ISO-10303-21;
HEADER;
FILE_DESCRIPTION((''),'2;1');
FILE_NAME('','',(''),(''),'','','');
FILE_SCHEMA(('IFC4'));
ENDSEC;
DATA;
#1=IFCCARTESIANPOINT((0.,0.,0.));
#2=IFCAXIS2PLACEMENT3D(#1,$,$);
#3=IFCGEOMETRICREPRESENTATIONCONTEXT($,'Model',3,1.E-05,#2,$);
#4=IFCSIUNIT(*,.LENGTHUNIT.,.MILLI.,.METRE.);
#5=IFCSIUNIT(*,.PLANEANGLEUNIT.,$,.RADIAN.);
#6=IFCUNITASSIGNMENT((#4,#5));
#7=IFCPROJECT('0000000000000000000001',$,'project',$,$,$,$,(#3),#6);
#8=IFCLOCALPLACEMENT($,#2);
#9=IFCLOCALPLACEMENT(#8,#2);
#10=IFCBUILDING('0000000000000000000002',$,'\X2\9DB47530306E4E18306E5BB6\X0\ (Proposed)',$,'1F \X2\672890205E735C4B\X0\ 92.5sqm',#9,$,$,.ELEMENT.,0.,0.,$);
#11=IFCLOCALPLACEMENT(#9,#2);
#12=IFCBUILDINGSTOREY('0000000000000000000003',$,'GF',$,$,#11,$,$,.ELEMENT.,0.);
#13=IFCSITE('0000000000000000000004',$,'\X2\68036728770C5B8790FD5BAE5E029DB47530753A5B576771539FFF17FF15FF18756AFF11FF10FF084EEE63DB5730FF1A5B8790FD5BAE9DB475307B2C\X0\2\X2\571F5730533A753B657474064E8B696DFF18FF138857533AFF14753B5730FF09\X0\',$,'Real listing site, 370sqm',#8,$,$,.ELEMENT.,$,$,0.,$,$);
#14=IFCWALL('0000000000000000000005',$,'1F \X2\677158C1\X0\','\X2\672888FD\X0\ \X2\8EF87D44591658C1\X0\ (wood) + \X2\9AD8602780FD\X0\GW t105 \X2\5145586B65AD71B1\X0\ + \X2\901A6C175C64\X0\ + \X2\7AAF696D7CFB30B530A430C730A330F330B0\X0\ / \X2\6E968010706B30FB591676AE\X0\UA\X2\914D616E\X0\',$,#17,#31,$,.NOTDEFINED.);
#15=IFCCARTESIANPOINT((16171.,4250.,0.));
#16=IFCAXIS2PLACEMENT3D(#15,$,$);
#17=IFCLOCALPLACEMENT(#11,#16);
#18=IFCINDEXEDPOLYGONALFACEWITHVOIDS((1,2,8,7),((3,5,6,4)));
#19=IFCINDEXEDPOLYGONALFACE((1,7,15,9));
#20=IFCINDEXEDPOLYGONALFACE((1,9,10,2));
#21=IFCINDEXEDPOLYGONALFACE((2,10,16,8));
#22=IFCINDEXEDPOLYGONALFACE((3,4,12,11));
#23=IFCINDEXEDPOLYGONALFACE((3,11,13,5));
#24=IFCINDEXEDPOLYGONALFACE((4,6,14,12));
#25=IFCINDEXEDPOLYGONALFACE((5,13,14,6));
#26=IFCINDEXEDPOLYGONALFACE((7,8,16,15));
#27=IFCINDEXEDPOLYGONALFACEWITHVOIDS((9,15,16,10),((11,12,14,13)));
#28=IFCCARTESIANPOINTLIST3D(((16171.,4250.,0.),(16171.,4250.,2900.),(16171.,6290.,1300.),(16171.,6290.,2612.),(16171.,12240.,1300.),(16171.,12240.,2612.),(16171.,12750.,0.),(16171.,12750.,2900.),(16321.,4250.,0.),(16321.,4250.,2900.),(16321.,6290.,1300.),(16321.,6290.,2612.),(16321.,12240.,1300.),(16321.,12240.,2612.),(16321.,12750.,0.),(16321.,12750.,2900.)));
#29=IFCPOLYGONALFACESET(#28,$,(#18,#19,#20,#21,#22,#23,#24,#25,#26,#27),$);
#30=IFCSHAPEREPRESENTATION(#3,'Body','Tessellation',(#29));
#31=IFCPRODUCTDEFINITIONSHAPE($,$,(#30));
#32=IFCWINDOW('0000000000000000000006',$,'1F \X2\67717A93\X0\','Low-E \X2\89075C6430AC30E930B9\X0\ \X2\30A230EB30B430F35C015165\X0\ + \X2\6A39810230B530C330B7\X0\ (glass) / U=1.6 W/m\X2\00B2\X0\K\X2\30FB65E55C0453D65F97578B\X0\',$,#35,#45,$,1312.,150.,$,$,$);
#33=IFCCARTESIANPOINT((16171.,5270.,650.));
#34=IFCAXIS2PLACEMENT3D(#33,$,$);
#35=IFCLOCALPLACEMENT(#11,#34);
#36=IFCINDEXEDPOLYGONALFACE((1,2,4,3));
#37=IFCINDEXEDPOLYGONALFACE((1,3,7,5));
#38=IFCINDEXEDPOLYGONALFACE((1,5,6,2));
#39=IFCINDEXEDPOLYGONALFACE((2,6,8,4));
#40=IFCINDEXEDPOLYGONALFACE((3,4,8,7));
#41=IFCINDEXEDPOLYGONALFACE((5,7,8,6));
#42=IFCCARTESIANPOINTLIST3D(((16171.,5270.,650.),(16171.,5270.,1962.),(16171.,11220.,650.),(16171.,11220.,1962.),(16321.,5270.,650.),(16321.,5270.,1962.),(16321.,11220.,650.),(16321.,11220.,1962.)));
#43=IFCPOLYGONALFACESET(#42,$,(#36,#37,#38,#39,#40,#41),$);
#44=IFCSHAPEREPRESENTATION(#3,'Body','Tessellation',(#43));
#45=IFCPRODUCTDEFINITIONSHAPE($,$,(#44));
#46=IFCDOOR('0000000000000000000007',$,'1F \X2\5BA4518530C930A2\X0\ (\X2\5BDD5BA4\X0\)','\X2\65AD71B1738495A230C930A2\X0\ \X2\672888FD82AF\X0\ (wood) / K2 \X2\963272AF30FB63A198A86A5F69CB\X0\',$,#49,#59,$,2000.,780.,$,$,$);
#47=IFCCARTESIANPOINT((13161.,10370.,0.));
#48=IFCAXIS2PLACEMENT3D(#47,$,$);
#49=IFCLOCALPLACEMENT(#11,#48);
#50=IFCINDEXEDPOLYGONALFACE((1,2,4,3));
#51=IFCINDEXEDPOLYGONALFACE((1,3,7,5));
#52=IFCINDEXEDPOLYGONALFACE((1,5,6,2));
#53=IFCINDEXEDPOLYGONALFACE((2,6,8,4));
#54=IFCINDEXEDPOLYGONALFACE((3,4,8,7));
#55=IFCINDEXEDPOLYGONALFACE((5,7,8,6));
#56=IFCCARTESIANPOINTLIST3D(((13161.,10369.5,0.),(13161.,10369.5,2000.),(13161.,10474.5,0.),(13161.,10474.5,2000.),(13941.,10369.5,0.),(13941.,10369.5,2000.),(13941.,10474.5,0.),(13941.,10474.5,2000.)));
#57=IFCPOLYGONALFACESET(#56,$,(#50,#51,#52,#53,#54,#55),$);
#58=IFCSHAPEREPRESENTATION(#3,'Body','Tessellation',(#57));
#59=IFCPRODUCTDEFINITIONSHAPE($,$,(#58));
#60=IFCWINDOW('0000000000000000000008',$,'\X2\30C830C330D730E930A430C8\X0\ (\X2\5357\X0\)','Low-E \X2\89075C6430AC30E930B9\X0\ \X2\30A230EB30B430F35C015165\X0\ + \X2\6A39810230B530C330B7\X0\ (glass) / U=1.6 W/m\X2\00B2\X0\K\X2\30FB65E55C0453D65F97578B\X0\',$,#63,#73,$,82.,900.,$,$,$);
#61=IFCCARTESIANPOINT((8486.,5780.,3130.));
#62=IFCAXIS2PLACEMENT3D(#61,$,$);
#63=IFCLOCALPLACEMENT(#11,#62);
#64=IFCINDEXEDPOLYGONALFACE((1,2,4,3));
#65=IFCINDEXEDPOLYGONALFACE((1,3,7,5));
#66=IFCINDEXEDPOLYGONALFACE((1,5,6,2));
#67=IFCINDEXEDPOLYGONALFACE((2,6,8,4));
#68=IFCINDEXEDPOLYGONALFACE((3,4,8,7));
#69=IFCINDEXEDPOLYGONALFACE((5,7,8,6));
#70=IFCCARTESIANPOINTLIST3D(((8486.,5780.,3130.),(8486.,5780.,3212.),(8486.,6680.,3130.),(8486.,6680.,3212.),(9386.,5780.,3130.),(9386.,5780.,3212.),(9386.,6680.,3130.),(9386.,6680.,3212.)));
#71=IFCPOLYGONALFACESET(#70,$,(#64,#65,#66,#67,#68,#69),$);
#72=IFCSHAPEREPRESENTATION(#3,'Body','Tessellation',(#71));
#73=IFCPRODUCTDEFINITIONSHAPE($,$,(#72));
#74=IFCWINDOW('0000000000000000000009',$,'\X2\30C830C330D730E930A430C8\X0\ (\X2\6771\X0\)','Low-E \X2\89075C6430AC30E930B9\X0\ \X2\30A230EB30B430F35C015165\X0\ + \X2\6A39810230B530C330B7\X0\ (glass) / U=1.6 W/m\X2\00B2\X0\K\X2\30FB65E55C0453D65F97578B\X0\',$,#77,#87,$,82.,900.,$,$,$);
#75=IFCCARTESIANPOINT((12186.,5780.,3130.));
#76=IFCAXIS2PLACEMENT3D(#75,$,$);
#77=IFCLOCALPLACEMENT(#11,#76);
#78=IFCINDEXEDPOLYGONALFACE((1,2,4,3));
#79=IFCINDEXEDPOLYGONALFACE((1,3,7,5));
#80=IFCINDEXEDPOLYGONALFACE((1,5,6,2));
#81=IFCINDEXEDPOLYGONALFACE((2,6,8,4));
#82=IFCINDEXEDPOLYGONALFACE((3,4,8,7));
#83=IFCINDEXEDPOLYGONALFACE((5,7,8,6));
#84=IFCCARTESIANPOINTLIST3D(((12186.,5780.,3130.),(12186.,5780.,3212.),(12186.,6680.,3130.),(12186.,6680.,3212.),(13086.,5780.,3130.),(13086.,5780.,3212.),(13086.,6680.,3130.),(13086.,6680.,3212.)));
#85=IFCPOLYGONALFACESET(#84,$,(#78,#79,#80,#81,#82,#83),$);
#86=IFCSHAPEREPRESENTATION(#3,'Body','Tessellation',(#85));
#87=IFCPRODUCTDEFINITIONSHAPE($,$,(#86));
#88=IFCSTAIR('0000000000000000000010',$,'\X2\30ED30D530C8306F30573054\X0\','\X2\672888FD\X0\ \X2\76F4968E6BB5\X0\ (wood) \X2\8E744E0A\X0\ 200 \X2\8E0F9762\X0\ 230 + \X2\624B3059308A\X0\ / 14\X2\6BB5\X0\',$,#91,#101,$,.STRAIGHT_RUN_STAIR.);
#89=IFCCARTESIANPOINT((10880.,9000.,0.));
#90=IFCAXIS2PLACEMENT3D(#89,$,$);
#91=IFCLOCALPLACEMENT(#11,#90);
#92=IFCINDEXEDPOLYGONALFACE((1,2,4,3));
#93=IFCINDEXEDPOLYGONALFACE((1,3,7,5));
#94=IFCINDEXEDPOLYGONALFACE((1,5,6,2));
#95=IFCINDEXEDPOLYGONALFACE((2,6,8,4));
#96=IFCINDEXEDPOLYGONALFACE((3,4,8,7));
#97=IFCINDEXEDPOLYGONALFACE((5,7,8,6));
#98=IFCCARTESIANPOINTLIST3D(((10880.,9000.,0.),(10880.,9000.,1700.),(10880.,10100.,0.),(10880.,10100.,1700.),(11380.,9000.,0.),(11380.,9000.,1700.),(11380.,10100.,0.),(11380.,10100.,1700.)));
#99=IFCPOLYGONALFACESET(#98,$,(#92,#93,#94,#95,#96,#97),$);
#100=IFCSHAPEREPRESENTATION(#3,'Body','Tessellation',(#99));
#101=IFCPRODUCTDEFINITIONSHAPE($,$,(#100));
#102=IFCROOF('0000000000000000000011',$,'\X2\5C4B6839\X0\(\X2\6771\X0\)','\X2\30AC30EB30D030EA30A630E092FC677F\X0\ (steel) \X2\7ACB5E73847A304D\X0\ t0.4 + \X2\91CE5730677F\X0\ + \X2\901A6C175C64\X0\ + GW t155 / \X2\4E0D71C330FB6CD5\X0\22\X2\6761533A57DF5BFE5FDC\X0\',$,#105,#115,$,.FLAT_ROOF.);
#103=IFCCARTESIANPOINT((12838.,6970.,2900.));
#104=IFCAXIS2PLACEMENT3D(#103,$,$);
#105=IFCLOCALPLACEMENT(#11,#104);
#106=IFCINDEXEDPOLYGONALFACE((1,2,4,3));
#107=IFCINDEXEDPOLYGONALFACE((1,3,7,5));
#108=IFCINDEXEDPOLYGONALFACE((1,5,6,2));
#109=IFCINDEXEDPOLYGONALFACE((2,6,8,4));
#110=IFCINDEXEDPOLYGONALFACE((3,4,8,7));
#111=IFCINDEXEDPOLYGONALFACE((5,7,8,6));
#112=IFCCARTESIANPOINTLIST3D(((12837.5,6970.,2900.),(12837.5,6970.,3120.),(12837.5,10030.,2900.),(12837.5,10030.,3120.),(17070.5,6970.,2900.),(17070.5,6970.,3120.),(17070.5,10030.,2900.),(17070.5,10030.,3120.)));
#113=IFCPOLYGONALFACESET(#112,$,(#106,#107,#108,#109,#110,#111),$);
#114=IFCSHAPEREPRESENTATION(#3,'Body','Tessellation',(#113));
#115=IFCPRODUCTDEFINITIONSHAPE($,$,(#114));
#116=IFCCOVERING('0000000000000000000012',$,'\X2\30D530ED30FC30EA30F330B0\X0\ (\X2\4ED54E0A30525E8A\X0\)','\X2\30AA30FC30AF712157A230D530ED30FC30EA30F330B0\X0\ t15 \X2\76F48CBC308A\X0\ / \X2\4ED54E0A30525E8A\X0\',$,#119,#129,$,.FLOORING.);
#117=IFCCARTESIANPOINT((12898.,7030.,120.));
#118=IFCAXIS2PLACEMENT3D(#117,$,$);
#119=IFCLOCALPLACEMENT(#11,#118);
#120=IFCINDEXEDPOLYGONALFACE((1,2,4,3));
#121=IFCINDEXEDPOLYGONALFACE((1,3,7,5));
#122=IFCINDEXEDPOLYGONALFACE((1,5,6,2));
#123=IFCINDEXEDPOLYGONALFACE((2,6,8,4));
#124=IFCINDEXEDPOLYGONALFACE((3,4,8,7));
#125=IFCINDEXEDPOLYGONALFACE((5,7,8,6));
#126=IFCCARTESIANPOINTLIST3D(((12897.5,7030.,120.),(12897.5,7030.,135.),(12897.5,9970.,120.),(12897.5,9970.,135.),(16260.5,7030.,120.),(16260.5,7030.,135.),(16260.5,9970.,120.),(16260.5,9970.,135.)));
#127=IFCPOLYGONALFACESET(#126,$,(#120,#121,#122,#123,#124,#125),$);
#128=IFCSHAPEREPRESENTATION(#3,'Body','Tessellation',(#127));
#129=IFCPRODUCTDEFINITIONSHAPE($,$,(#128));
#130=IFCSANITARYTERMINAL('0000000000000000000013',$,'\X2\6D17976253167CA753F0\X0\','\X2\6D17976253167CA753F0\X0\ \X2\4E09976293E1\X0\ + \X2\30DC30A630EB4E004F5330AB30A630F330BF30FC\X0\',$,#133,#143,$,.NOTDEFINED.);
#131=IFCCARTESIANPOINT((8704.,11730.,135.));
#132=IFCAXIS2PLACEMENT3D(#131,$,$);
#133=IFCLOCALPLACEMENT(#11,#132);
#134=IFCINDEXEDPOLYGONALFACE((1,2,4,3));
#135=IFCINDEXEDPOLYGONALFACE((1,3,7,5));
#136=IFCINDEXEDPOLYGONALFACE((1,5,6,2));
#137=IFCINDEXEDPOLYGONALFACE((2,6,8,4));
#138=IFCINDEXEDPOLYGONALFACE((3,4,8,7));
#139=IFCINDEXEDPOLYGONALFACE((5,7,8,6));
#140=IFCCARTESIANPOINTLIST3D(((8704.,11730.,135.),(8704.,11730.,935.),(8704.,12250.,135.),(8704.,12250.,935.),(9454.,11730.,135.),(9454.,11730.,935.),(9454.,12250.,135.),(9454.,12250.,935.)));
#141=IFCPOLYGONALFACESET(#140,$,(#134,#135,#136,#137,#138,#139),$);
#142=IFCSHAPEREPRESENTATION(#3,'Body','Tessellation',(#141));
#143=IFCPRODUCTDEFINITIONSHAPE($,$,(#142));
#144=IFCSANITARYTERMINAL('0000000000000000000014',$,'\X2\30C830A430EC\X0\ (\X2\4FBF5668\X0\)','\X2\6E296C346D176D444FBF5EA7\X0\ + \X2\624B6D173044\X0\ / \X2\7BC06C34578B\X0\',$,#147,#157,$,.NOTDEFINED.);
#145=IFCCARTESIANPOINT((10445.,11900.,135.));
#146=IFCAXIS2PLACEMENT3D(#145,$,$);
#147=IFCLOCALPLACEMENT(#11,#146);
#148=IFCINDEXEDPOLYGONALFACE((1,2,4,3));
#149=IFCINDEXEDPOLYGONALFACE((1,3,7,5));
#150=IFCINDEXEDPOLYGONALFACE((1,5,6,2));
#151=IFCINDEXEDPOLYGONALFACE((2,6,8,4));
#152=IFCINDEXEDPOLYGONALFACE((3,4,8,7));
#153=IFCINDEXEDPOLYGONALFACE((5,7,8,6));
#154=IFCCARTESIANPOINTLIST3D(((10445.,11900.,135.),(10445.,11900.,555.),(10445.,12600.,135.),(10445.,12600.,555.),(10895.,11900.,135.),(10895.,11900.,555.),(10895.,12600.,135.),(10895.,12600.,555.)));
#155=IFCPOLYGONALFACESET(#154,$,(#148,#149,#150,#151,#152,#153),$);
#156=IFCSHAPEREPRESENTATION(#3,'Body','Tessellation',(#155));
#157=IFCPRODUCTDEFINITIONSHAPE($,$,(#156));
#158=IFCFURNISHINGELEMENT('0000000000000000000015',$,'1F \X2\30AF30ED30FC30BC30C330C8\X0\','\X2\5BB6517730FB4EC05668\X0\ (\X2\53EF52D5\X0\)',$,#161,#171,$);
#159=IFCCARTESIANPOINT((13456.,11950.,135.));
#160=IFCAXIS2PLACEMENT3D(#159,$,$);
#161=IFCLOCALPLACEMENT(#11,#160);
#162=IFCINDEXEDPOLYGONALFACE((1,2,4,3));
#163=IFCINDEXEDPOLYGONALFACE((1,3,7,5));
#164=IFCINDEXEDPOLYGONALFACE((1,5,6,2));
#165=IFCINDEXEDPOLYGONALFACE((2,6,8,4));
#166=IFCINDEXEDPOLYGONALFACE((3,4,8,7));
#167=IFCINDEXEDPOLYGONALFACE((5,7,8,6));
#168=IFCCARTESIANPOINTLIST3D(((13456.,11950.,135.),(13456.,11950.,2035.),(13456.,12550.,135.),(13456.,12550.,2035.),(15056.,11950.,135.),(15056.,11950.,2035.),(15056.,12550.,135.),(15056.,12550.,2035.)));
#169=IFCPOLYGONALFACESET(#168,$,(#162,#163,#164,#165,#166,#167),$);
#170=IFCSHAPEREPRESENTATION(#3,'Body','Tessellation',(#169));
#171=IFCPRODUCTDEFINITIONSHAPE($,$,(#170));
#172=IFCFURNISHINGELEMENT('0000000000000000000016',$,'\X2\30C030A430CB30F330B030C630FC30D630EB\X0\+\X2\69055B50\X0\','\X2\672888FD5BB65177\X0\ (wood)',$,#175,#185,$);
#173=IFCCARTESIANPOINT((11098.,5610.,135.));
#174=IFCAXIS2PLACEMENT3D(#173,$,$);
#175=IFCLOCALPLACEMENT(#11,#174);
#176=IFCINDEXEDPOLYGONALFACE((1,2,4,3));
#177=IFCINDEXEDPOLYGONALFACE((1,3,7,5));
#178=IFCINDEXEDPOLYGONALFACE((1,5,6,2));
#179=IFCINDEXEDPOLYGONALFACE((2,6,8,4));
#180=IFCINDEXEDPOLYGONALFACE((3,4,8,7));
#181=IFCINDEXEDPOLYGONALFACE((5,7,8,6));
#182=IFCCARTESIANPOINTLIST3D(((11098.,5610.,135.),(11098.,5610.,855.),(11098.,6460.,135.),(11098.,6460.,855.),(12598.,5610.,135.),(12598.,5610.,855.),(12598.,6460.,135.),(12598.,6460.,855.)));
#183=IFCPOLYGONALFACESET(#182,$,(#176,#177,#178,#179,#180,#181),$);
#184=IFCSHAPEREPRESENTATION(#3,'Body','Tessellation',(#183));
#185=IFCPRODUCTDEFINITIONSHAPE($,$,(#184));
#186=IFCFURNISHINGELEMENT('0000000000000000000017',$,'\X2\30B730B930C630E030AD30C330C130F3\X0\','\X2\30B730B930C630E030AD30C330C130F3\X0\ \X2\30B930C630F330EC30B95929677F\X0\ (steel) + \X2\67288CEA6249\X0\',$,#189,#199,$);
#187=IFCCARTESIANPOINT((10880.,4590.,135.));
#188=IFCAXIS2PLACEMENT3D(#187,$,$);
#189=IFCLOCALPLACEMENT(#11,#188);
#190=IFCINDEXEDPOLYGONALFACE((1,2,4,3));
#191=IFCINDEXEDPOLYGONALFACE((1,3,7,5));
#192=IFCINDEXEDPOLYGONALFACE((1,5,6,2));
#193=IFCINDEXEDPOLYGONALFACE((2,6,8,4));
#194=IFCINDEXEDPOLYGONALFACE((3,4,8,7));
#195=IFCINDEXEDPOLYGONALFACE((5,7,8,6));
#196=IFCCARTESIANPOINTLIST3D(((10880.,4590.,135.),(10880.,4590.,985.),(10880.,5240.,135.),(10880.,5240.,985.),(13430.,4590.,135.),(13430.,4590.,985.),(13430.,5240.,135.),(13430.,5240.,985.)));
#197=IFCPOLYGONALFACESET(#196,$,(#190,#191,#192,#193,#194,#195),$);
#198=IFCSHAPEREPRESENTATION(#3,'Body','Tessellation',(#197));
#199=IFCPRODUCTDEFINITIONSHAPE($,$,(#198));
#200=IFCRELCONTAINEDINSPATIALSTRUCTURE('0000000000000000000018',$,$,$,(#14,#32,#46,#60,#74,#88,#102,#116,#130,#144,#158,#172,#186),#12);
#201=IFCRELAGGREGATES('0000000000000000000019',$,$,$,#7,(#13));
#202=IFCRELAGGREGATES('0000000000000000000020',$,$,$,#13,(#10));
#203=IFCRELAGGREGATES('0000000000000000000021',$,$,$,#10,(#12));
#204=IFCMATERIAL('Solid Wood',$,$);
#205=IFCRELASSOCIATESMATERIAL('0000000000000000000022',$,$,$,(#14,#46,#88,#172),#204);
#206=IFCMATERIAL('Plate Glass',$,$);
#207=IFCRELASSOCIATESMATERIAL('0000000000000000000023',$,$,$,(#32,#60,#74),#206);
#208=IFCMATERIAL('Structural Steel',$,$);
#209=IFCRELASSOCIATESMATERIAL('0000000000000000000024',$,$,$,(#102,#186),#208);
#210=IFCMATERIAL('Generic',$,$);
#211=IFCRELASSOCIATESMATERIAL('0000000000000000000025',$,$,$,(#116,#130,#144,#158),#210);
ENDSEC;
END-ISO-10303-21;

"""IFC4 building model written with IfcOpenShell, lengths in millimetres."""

from ifc_helpers import new_model, si_unit, frame, frame_2d, origin, place, context, project, spatial, rectangle, extrude, material, element, fill, save


model = new_model("IFC4")

# Units and contexts
model_context = context("Model", 3, precision=1e-05, world=origin())
ifc_project = project(units=[si_unit("LENGTHUNIT", "METRE", prefix="MILLI"), si_unit("PLANEANGLEUNIT", "RADIAN")], contexts=[model_context])

# Site, building, storey
site_placement = place(None, origin())
site = spatial("IfcSite", under=ifc_project, at=site_placement, Name="栃木県宇都宮市鶴田町字東原７５８番１０（仮換地：宇都宮鶴田第2土地区画整理事業８３街区４画地）", ObjectType="Real listing site, 370sqm", CompositionType="ELEMENT", RefElevation=0.0)
building_placement = place(site_placement, origin())
building = spatial("IfcBuilding", under=site, at=building_placement, Name="鶴田の丘の家 (Proposed)", ObjectType="1F 木造平屋 92.5sqm", CompositionType="ELEMENT", ElevationOfRefHeight=0.0, ElevationOfTerrain=0.0)
storey_placement = place(building_placement, origin())
storey = spatial("IfcBuildingStorey", under=building, at=storey_placement, Name="GF", CompositionType="ELEMENT", Elevation=0.0)

# Shared definitions
ifc_material_1 = material(Name="Solid Wood")

# Wall, opening, window
wall_1_placement = place(storey_placement, frame((16171.0, 4250.0, 0.0)))
wall_1 = element("IfcWall", 1, at=wall_1_placement, inside=storey, material=ifc_material_1, Name="1F 東壁", Description="木製 軸組外壁 (wood) + 高性能GW t105 充填断熱 + 通気層 + 窯業系サイディング / 準耐火・外皮UA配慮", PredefinedType="NOTDEFINED", context=model_context, shape_type="SweptSolid", body=[
    extrude(rectangle(XDim=150.0, YDim=8500.0, at=frame_2d((75.0, 4250.0))), frame((16171.0, 4250.0, 0.0)), (0.0, 0.0, 1.0), 2900.0),
])
opening_1_placement = place(storey_placement, frame((16171.0, 5270.0, 650.0)))
opening_1 = element("IfcOpeningElement", 2, at=opening_1_placement, cuts=wall_1, PredefinedType="NOTDEFINED", context=model_context, shape_type="SweptSolid", body=[
    extrude(rectangle(XDim=150.0, YDim=5950.0, at=frame_2d((75.0, 2975.0))), frame((16171.0, 5270.0, 650.0)), (0.0, 0.0, 1.0), 1312.0),
])
ifc_material_2 = material(Name="Plate Glass")
window_1_placement = place(storey_placement, frame((16171.0, 5270.0, 650.0)))
window_1 = element("IfcWindow", 3, at=window_1_placement, inside=storey, material=ifc_material_2, Name="1F 東窓", Description="Low-E 複層ガラス アルゴン封入 + 樹脂サッシ (glass) / U=1.6 W/m²K・日射取得型", OverallHeight=1312.0, OverallWidth=150.0, context=model_context, shape_type="SweptSolid", body=[
    extrude(rectangle(XDim=150.0, YDim=5950.0, at=frame_2d((75.0, 2975.0))), frame((16171.0, 5270.0, 650.0)), (0.0, 0.0, 1.0), 1312.0),
])
fill(opening_1, window_1)

# Door
door_placement = place(storey_placement, frame((13161.0, 10370.0, 0.0)))
element("IfcDoor", 4, at=door_placement, inside=storey, material=ifc_material_1, Name="1F 室内ドア (寝室)", Description="断熱玄関ドア 木製芯 (wood) / K2 防犯・採風機構", OverallHeight=2000.0, OverallWidth=780.0, context=model_context, shape_type="SweptSolid", body=[
    extrude(rectangle(XDim=780.0, YDim=105.0, at=frame_2d((390.0, 52.0))), frame((13161.0, 10370.0, 0.0)), (0.0, 0.0, 1.0), 2000.0),
])

# Windows
window_2_placement = place(storey_placement, frame((8486.0, 5780.0, 3130.0)))
element("IfcWindow", 5, at=window_2_placement, inside=storey, material=ifc_material_2, Name="トップライト (南)", Description="Low-E 複層ガラス アルゴン封入 + 樹脂サッシ (glass) / U=1.6 W/m²K・日射取得型", OverallHeight=82.0, OverallWidth=900.0, context=model_context, shape_type="SweptSolid", body=[
    extrude(rectangle(XDim=900.0, YDim=900.0, at=frame_2d((450.0, 450.0))), frame((8486.0, 5780.0, 3130.0)), (0.0, 0.0, 1.0), 82.0),
])
window_3_placement = place(storey_placement, frame((12186.0, 5780.0, 3130.0)))
element("IfcWindow", 6, at=window_3_placement, inside=storey, material=ifc_material_2, Name="トップライト (東)", Description="Low-E 複層ガラス アルゴン封入 + 樹脂サッシ (glass) / U=1.6 W/m²K・日射取得型", OverallHeight=82.0, OverallWidth=900.0, context=model_context, shape_type="SweptSolid", body=[
    extrude(rectangle(XDim=900.0, YDim=900.0, at=frame_2d((450.0, 450.0))), frame((12186.0, 5780.0, 3130.0)), (0.0, 0.0, 1.0), 82.0),
])

# Stair
stair_placement = place(storey_placement, frame((10880.0, 9000.0, 0.0)))
element("IfcStair", 7, at=stair_placement, inside=storey, material=ifc_material_1, Name="ロフトはしご", Description="木製 直階段 (wood) 蹴上 200 踏面 230 + 手すり / 14段", PredefinedType="STRAIGHT_RUN_STAIR", context=model_context, shape_type="SweptSolid", body=[
    extrude(rectangle(XDim=500.0, YDim=1100.0, at=frame_2d((250.0, 550.0))), frame((10880.0, 9000.0, 0.0)), (0.0, 0.0, 1.0), 1700.0),
])

# Roof
ifc_material_3 = material(Name="Structural Steel")
roof_placement = place(storey_placement, frame((12838.0, 6970.0, 2900.0)))
element("IfcRoof", 8, at=roof_placement, inside=storey, material=ifc_material_3, Name="屋根(東)", Description="ガルバリウム鋼板 (steel) 立平葺き t0.4 + 野地板 + 通気層 + GW t155 / 不燃・法22条区域対応", PredefinedType="FLAT_ROOF", context=model_context, shape_type="SweptSolid", body=[
    extrude(rectangle(XDim=4233.0, YDim=3060.0, at=frame_2d((2116.0, 1530.0))), frame((12838.0, 6970.0, 2900.0)), (0.0, 0.0, 1.0), 220.0),
])

# Covering
ifc_material_4 = material(Name="Generic")
covering_placement = place(storey_placement, frame((12898.0, 7030.0, 120.0)))
element("IfcCovering", 9, at=covering_placement, inside=storey, material=ifc_material_4, Name="フローリング (仕上げ床)", Description="オーク無垢フローリング t15 直貼り / 仕上げ床", PredefinedType="FLOORING", context=model_context, shape_type="SweptSolid", body=[
    extrude(rectangle(XDim=3363.0, YDim=2940.0, at=frame_2d((1681.0, 1470.0))), frame((12898.0, 7030.0, 120.0)), (0.0, 0.0, 1.0), 15.0),
])

# Sanitary terminals
sanitary_terminal_1_placement = place(storey_placement, frame((8704.0, 11730.0, 135.0)))
element("IfcSanitaryTerminal", 10, at=sanitary_terminal_1_placement, inside=storey, material=ifc_material_4, Name="洗面化粧台", Description="洗面化粧台 三面鏡 + ボウル一体カウンター", PredefinedType="NOTDEFINED", context=model_context, shape_type="SweptSolid", body=[
    extrude(rectangle(XDim=750.0, YDim=520.0, at=frame_2d((375.0, 260.0))), frame((8704.0, 11730.0, 135.0)), (0.0, 0.0, 1.0), 800.0),
])
sanitary_terminal_2_placement = place(storey_placement, frame((10445.0, 11900.0, 135.0)))
element("IfcSanitaryTerminal", 11, at=sanitary_terminal_2_placement, inside=storey, material=ifc_material_4, Name="トイレ (便器)", Description="温水洗浄便座 + 手洗い / 節水型", PredefinedType="NOTDEFINED", context=model_context, shape_type="SweptSolid", body=[
    extrude(rectangle(XDim=450.0, YDim=700.0, at=frame_2d((225.0, 350.0))), frame((10445.0, 11900.0, 135.0)), (0.0, 0.0, 1.0), 420.0),
])

# Furnishing elements
furnishing_1_placement = place(storey_placement, frame((13456.0, 11950.0, 135.0)))
element("IfcFurnishingElement", 12, at=furnishing_1_placement, inside=storey, material=ifc_material_4, Name="1F クローゼット", Description="家具・什器 (可動)", context=model_context, shape_type="SweptSolid", body=[
    extrude(rectangle(XDim=1600.0, YDim=600.0, at=frame_2d((800.0, 300.0))), frame((13456.0, 11950.0, 135.0)), (0.0, 0.0, 1.0), 1900.0),
])
furnishing_2_placement = place(storey_placement, frame((11098.0, 5610.0, 135.0)))
element("IfcFurnishingElement", 13, at=furnishing_2_placement, inside=storey, material=ifc_material_1, Name="ダイニングテーブル+椅子", Description="木製家具 (wood)", context=model_context, shape_type="SweptSolid", body=[
    extrude(rectangle(XDim=1500.0, YDim=850.0, at=frame_2d((750.0, 425.0))), frame((11098.0, 5610.0, 135.0)), (0.0, 0.0, 1.0), 720.0),
])
furnishing_3_placement = place(storey_placement, frame((10880.0, 4590.0, 135.0)))
element("IfcFurnishingElement", 14, at=furnishing_3_placement, inside=storey, material=ifc_material_3, Name="システムキッチン", Description="システムキッチン ステンレス天板 (steel) + 木質扉", context=model_context, shape_type="SweptSolid", body=[
    extrude(rectangle(XDim=2550.0, YDim=650.0, at=frame_2d((1275.0, 325.0))), frame((10880.0, 4590.0, 135.0)), (0.0, 0.0, 1.0), 850.0),
])

save(model, "model.ifc")
